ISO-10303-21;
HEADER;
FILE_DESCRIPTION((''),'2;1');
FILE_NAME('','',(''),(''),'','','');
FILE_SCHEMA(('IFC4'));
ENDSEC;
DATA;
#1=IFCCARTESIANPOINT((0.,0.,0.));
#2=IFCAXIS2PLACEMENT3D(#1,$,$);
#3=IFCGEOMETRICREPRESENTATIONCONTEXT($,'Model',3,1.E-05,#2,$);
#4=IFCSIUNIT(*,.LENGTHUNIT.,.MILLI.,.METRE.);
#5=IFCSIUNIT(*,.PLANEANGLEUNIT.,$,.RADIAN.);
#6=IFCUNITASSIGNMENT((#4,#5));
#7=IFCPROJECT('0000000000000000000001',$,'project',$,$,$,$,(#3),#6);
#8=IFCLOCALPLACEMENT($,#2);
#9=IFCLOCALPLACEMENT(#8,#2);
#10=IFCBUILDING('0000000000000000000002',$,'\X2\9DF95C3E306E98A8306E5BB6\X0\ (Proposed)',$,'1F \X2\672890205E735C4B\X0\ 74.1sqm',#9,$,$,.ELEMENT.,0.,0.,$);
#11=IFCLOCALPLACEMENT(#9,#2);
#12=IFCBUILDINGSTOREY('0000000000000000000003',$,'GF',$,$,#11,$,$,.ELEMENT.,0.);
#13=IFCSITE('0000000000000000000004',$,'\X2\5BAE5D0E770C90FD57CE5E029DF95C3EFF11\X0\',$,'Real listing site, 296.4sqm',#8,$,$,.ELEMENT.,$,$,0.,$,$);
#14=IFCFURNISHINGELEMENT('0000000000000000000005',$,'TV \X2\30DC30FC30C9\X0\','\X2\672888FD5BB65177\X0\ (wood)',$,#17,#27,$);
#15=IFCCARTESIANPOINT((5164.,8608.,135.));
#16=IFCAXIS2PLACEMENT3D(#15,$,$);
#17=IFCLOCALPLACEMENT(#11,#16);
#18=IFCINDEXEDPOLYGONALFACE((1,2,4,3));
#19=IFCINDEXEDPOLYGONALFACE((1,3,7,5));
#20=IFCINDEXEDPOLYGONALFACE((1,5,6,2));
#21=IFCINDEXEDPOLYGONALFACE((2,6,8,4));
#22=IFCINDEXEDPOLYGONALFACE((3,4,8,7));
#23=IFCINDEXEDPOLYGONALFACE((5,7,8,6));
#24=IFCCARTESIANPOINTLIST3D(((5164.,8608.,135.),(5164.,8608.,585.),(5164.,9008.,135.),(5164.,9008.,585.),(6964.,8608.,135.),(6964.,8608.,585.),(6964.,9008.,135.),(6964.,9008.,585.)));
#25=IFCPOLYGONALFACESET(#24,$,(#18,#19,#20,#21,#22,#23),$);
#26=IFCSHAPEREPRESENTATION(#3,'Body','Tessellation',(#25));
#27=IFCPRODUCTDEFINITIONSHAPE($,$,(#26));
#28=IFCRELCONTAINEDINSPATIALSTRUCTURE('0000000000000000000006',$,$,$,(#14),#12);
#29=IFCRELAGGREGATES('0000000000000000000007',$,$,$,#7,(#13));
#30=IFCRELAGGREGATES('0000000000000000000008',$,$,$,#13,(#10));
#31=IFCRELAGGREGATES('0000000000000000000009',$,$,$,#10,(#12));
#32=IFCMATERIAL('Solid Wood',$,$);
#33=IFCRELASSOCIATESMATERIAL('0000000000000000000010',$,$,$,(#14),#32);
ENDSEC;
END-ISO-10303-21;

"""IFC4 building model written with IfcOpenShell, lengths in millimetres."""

from ifc_helpers import new_model, si_unit, frame, frame_2d, origin, place, context, project, spatial, rectangle, extrude, material, element, save


model = new_model("IFC4")

# Units and contexts
model_context = context("Model", 3, precision=1e-05, world=origin())
ifc_project = project(units=[si_unit("LENGTHUNIT", "METRE", prefix="MILLI"), si_unit("PLANEANGLEUNIT", "RADIAN")], contexts=[model_context])

# Site, building, storey
site_placement = place(None, origin())
site = spatial("IfcSite", under=ifc_project, at=site_placement, Name="宮崎県都城市鷹尾１", ObjectType="Real listing site, 296.4sqm", CompositionType="ELEMENT", RefElevation=0.0)
building_placement = place(site_placement, origin())
building = spatial("IfcBuilding", under=site, at=building_placement, Name="鷹尾の風の家 (Proposed)", ObjectType="1F 木造平屋 74.1sqm", CompositionType="ELEMENT", ElevationOfRefHeight=0.0, ElevationOfTerrain=0.0)
storey_placement = place(building_placement, origin())
storey = spatial("IfcBuildingStorey", under=building, at=storey_placement, Name="GF", CompositionType="ELEMENT", Elevation=0.0)

# Shared definitions
ifc_material_1 = material(Name="Solid Wood")

# Furnishing element
furnishing_1_placement = place(storey_placement, frame((5164.0, 8608.0, 135.0)))
element("IfcFurnishingElement", 1, at=furnishing_1_placement, inside=storey, material=ifc_material_1, Name="TV ボード", Description="木製家具 (wood)", context=model_context, shape_type="SweptSolid", body=[
    extrude(rectangle(XDim=1800.0, YDim=400.0, at=frame_2d((900.0, 200.0))), frame((5164.0, 8608.0, 135.0)), (0.0, 0.0, 1.0), 450.0),
])

save(model, "model.ifc")
